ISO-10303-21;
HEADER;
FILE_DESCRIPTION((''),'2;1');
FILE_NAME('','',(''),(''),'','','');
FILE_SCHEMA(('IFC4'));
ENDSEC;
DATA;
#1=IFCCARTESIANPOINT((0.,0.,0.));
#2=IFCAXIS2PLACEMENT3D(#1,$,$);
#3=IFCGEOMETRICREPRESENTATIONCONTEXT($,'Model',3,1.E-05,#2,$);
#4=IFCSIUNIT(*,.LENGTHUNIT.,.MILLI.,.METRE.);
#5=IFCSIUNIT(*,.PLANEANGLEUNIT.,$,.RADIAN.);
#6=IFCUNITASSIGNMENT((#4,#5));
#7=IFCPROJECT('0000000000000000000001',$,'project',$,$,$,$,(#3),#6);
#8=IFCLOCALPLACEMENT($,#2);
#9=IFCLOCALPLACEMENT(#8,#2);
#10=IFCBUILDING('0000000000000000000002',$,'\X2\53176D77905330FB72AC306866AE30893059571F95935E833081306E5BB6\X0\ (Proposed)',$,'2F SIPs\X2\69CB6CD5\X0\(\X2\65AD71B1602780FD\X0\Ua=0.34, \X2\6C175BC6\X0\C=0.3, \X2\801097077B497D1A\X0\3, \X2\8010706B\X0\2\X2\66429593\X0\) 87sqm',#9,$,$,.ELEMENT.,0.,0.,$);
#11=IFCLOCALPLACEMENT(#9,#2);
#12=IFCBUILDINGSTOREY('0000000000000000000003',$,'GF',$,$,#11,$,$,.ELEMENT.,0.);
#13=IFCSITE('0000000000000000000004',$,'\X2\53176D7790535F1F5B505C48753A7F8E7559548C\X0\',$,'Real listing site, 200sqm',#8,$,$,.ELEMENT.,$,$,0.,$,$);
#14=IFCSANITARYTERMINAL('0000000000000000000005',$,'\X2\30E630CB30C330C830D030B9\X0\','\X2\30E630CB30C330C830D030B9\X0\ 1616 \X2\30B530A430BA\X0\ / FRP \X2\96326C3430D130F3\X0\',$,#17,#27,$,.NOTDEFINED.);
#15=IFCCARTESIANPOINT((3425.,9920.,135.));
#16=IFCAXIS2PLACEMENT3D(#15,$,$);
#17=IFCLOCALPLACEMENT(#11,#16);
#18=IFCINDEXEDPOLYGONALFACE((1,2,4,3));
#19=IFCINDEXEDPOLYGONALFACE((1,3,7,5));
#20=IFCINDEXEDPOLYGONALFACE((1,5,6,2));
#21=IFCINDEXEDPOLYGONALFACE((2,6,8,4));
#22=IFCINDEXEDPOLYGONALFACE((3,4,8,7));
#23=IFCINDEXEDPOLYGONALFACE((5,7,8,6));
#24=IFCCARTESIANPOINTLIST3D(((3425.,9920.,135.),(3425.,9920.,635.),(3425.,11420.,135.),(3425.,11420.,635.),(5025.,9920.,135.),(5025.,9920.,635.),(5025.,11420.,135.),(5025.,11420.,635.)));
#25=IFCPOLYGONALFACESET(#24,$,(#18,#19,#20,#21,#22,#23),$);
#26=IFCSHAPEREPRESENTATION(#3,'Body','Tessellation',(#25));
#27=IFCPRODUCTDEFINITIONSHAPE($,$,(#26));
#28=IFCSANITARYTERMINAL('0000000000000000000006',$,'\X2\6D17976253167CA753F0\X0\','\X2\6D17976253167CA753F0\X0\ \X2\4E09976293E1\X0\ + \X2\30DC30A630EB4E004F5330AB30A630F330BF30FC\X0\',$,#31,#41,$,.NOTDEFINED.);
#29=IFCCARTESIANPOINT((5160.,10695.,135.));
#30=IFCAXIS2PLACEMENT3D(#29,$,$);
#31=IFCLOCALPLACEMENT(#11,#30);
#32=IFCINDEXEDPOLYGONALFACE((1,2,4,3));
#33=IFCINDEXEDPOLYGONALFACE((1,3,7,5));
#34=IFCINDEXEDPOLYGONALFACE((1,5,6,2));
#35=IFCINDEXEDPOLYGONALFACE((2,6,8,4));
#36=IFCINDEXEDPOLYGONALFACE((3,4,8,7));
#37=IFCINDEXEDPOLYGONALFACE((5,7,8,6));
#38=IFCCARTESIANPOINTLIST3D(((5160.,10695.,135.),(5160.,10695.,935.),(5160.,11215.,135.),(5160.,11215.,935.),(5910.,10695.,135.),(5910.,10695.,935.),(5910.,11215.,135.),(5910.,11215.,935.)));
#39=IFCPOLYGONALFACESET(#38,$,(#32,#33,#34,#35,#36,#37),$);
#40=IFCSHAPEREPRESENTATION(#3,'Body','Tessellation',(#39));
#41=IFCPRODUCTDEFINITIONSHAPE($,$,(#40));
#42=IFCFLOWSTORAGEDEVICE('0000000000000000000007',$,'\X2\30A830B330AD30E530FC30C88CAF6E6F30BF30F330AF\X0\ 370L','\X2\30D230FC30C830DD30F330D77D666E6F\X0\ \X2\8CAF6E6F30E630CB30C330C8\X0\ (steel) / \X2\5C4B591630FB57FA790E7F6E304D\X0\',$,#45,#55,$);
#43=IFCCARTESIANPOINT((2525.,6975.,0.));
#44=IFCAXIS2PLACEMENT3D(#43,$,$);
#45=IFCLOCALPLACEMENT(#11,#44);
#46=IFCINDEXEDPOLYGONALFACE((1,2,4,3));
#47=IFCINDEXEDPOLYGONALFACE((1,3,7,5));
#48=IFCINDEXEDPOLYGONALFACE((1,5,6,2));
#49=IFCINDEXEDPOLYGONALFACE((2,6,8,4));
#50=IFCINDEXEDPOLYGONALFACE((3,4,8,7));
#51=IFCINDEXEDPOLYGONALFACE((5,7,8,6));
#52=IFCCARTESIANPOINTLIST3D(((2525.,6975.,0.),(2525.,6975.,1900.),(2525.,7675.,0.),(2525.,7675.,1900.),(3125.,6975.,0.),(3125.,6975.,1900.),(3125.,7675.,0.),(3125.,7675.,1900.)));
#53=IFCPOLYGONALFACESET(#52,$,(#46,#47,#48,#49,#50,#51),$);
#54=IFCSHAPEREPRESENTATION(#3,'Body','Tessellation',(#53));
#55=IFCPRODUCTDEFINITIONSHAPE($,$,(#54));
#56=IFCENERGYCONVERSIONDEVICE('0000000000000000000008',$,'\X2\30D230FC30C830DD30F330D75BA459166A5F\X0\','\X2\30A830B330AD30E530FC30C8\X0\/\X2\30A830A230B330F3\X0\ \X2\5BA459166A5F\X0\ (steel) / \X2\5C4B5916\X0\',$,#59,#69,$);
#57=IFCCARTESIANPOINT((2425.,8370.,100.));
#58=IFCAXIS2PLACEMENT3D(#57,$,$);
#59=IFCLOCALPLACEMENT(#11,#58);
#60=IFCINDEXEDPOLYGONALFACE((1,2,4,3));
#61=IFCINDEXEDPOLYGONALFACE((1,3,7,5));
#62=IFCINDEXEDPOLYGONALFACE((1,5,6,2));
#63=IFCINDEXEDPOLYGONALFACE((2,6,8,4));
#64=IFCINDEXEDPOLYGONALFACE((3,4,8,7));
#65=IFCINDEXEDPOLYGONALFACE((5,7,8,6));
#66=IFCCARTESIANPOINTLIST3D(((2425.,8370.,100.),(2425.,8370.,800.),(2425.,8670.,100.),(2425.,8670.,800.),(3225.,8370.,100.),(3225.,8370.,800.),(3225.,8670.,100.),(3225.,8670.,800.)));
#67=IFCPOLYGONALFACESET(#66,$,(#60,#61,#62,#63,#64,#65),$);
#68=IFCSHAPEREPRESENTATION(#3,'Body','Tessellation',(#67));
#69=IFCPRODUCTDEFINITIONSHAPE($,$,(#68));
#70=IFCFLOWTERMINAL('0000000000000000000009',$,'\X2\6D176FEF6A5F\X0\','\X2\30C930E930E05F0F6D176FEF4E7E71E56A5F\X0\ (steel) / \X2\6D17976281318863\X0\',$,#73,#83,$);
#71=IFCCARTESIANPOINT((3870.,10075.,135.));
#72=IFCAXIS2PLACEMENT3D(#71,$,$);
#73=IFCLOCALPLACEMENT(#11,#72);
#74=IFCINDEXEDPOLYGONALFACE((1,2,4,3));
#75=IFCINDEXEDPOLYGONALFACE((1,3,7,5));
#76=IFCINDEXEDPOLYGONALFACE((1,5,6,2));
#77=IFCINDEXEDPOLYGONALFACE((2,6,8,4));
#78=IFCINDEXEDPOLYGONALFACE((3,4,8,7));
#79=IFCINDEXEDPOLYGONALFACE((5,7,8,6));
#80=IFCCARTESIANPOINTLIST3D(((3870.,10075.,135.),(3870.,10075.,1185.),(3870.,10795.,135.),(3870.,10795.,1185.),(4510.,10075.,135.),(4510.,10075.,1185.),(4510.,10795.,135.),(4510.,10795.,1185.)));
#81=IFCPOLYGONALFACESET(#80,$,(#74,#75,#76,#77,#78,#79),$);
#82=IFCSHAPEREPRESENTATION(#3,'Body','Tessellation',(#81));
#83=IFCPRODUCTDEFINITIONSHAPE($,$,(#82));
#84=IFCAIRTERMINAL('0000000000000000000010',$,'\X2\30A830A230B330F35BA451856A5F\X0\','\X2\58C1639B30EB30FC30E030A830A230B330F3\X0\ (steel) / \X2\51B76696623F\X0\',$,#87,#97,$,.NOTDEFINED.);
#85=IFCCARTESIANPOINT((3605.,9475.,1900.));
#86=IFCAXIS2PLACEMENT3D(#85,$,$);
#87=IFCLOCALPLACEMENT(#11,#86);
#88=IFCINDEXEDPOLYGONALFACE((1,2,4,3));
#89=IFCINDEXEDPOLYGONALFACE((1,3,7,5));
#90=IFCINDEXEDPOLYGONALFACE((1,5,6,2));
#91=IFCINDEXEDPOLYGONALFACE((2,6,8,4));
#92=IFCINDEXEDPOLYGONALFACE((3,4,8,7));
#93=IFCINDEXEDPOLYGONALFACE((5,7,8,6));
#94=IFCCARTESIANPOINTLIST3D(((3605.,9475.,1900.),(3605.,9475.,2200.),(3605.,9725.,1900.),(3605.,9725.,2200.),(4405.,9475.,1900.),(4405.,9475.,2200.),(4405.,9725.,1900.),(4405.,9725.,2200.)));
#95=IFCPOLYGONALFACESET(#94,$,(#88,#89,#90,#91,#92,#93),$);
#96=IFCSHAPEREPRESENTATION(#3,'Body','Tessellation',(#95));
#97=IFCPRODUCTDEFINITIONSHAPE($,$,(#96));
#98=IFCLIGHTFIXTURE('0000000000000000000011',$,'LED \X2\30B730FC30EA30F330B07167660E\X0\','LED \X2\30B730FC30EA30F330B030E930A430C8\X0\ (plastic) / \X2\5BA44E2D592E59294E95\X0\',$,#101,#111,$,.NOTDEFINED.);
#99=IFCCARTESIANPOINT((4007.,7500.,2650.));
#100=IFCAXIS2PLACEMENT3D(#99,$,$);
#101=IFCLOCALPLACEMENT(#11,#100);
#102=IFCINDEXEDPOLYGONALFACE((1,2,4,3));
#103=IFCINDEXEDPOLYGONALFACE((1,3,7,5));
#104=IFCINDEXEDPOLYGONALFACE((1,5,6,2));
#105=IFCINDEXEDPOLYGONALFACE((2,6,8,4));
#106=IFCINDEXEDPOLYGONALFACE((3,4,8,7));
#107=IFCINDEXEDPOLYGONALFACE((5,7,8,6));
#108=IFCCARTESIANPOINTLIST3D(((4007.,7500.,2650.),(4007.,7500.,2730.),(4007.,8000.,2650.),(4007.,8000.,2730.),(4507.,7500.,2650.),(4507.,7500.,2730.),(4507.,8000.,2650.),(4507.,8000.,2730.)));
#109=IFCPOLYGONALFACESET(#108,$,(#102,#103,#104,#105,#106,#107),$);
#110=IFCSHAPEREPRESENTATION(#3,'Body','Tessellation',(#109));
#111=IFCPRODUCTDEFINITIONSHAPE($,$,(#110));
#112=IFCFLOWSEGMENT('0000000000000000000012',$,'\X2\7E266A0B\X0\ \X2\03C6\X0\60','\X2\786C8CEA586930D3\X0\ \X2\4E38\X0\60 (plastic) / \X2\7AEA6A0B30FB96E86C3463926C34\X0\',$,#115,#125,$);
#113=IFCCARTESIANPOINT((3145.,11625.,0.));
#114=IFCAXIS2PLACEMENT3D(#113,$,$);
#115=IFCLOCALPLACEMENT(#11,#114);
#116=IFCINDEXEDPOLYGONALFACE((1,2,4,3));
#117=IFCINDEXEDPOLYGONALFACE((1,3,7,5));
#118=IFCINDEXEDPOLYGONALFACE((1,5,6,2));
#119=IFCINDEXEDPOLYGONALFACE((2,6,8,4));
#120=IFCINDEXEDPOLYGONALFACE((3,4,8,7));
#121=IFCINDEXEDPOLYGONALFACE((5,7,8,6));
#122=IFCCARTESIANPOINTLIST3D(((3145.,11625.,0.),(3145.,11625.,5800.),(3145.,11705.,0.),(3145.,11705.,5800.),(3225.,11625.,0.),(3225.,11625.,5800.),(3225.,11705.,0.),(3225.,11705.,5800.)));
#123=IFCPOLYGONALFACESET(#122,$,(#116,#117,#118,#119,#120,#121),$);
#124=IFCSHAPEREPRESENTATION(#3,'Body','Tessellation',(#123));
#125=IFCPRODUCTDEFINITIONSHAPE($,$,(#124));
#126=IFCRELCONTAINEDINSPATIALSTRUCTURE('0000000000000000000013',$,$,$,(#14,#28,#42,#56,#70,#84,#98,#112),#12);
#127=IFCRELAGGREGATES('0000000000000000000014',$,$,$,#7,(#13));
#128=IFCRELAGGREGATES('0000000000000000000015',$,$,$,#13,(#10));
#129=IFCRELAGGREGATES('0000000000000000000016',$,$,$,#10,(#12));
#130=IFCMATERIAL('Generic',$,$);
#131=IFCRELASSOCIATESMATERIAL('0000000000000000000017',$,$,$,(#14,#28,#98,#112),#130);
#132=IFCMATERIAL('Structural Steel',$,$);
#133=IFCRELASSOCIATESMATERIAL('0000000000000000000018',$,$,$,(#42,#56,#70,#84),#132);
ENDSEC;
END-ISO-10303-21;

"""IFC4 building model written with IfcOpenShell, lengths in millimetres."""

from ifc_helpers import new_model, si_unit, frame, frame_2d, origin, place, context, project, spatial, rectangle, extrude, material, element, save


model = new_model("IFC4")

# Units and contexts
model_context = context("Model", 3, precision=1e-05, world=origin())
ifc_project = project(units=[si_unit("LENGTHUNIT", "METRE", prefix="MILLI"), si_unit("PLANEANGLEUNIT", "RADIAN")], contexts=[model_context])

# Site, building, storey
site_placement = place(None, origin())
site = spatial("IfcSite", under=ifc_project, at=site_placement, Name="北海道弟子屈町美留和", ObjectType="Real listing site, 200sqm", CompositionType="ELEMENT", RefElevation=0.0)
building_placement = place(site_placement, origin())
building = spatial("IfcBuilding", under=site, at=building_placement, Name="北海道・犬と暮らす土間広めの家 (Proposed)", ObjectType="2F SIPs構法(断熱性能Ua=0.34, 気密C=0.3, 耐震等級3, 耐火2時間) 87sqm", CompositionType="ELEMENT", ElevationOfRefHeight=0.0, ElevationOfTerrain=0.0)
storey_placement = place(building_placement, origin())
storey = spatial("IfcBuildingStorey", under=building, at=storey_placement, Name="GF", CompositionType="ELEMENT", Elevation=0.0)

# Shared definitions
ifc_material_1 = material(Name="Generic")

# Sanitary terminals
sanitary_terminal_1_placement = place(storey_placement, frame((3425.0, 9920.0, 135.0)))
element("IfcSanitaryTerminal", 1, at=sanitary_terminal_1_placement, inside=storey, material=ifc_material_1, Name="ユニットバス", Description="ユニットバス 1616 サイズ / FRP 防水パン", PredefinedType="NOTDEFINED", context=model_context, shape_type="SweptSolid", body=[
    extrude(rectangle(XDim=1600.0, YDim=1500.0, at=frame_2d((800.0, 750.0))), frame((3425.0, 9920.0, 135.0)), (0.0, 0.0, 1.0), 500.0),
])
sanitary_terminal_2_placement = place(storey_placement, frame((5160.0, 10695.0, 135.0)))
element("IfcSanitaryTerminal", 2, at=sanitary_terminal_2_placement, inside=storey, material=ifc_material_1, Name="洗面化粧台", Description="洗面化粧台 三面鏡 + ボウル一体カウンター", PredefinedType="NOTDEFINED", context=model_context, shape_type="SweptSolid", body=[
    extrude(rectangle(XDim=750.0, YDim=520.0, at=frame_2d((375.0, 260.0))), frame((5160.0, 10695.0, 135.0)), (0.0, 0.0, 1.0), 800.0),
])

# Flow storage device
ifc_material_2 = material(Name="Structural Steel")
flow_storage_device_placement = place(storey_placement, frame((2525.0, 6975.0, 0.0)))
element("IfcFlowStorageDevice", 3, at=flow_storage_device_placement, inside=storey, material=ifc_material_2, Name="エコキュート貯湯タンク 370L", Description="ヒートポンプ給湯 貯湯ユニット (steel) / 屋外・基礎置き", context=model_context, shape_type="SweptSolid", body=[
    extrude(rectangle(XDim=600.0, YDim=700.0, at=frame_2d((300.0, 350.0))), frame((2525.0, 6975.0, 0.0)), (0.0, 0.0, 1.0), 1900.0),
])

# Energy conversion device
energy_conversion_device_placement = place(storey_placement, frame((2425.0, 8370.0, 100.0)))
element("IfcEnergyConversionDevice", 4, at=energy_conversion_device_placement, inside=storey, material=ifc_material_2, Name="ヒートポンプ室外機", Description="エコキュート/エアコン 室外機 (steel) / 屋外", context=model_context, shape_type="SweptSolid", body=[
    extrude(rectangle(XDim=800.0, YDim=300.0, at=frame_2d((400.0, 150.0))), frame((2425.0, 8370.0, 100.0)), (0.0, 0.0, 1.0), 700.0),
])

# Flow terminal
flow_terminal_placement = place(storey_placement, frame((3870.0, 10075.0, 135.0)))
element("IfcFlowTerminal", 5, at=flow_terminal_placement, inside=storey, material=ifc_material_2, Name="洗濯機", Description="ドラム式洗濯乾燥機 (steel) / 洗面脱衣", context=model_context, shape_type="SweptSolid", body=[
    extrude(rectangle(XDim=640.0, YDim=720.0, at=frame_2d((320.0, 360.0))), frame((3870.0, 10075.0, 135.0)), (0.0, 0.0, 1.0), 1050.0),
])

# Air terminal
air_terminal_placement = place(storey_placement, frame((3605.0, 9475.0, 1900.0)))
element("IfcAirTerminal", 6, at=air_terminal_placement, inside=storey, material=ifc_material_2, Name="エアコン室内機", Description="壁掛ルームエアコン (steel) / 冷暖房", PredefinedType="NOTDEFINED", context=model_context, shape_type="SweptSolid", body=[
    extrude(rectangle(XDim=800.0, YDim=250.0, at=frame_2d((400.0, 125.0))), frame((3605.0, 9475.0, 1900.0)), (0.0, 0.0, 1.0), 300.0),
])

# Light fixture
light_fixture_placement = place(storey_placement, frame((4007.0, 7500.0, 2650.0)))
element("IfcLightFixture", 7, at=light_fixture_placement, inside=storey, material=ifc_material_1, Name="LED シーリング照明", Description="LED シーリングライト (plastic) / 室中央天井", PredefinedType="NOTDEFINED", context=model_context, shape_type="SweptSolid", body=[
    extrude(rectangle(XDim=500.0, YDim=500.0, at=frame_2d((250.0, 250.0))), frame((4007.0, 7500.0, 2650.0)), (0.0, 0.0, 1.0), 80.0),
])

# Flow segment
flow_segment_placement = place(storey_placement, frame((3145.0, 11625.0, 0.0)))
element("IfcFlowSegment", 8, at=flow_segment_placement, inside=storey, material=ifc_material_1, Name="縦樋 φ60", Description="硬質塩ビ 丸60 (plastic) / 竪樋・雨水排水", context=model_context, shape_type="SweptSolid", body=[
    extrude(rectangle(XDim=80.0, YDim=80.0, at=frame_2d((40.0, 40.0))), frame((3145.0, 11625.0, 0.0)), (0.0, 0.0, 1.0), 5800.0),
])

save(model, "model.ifc")
